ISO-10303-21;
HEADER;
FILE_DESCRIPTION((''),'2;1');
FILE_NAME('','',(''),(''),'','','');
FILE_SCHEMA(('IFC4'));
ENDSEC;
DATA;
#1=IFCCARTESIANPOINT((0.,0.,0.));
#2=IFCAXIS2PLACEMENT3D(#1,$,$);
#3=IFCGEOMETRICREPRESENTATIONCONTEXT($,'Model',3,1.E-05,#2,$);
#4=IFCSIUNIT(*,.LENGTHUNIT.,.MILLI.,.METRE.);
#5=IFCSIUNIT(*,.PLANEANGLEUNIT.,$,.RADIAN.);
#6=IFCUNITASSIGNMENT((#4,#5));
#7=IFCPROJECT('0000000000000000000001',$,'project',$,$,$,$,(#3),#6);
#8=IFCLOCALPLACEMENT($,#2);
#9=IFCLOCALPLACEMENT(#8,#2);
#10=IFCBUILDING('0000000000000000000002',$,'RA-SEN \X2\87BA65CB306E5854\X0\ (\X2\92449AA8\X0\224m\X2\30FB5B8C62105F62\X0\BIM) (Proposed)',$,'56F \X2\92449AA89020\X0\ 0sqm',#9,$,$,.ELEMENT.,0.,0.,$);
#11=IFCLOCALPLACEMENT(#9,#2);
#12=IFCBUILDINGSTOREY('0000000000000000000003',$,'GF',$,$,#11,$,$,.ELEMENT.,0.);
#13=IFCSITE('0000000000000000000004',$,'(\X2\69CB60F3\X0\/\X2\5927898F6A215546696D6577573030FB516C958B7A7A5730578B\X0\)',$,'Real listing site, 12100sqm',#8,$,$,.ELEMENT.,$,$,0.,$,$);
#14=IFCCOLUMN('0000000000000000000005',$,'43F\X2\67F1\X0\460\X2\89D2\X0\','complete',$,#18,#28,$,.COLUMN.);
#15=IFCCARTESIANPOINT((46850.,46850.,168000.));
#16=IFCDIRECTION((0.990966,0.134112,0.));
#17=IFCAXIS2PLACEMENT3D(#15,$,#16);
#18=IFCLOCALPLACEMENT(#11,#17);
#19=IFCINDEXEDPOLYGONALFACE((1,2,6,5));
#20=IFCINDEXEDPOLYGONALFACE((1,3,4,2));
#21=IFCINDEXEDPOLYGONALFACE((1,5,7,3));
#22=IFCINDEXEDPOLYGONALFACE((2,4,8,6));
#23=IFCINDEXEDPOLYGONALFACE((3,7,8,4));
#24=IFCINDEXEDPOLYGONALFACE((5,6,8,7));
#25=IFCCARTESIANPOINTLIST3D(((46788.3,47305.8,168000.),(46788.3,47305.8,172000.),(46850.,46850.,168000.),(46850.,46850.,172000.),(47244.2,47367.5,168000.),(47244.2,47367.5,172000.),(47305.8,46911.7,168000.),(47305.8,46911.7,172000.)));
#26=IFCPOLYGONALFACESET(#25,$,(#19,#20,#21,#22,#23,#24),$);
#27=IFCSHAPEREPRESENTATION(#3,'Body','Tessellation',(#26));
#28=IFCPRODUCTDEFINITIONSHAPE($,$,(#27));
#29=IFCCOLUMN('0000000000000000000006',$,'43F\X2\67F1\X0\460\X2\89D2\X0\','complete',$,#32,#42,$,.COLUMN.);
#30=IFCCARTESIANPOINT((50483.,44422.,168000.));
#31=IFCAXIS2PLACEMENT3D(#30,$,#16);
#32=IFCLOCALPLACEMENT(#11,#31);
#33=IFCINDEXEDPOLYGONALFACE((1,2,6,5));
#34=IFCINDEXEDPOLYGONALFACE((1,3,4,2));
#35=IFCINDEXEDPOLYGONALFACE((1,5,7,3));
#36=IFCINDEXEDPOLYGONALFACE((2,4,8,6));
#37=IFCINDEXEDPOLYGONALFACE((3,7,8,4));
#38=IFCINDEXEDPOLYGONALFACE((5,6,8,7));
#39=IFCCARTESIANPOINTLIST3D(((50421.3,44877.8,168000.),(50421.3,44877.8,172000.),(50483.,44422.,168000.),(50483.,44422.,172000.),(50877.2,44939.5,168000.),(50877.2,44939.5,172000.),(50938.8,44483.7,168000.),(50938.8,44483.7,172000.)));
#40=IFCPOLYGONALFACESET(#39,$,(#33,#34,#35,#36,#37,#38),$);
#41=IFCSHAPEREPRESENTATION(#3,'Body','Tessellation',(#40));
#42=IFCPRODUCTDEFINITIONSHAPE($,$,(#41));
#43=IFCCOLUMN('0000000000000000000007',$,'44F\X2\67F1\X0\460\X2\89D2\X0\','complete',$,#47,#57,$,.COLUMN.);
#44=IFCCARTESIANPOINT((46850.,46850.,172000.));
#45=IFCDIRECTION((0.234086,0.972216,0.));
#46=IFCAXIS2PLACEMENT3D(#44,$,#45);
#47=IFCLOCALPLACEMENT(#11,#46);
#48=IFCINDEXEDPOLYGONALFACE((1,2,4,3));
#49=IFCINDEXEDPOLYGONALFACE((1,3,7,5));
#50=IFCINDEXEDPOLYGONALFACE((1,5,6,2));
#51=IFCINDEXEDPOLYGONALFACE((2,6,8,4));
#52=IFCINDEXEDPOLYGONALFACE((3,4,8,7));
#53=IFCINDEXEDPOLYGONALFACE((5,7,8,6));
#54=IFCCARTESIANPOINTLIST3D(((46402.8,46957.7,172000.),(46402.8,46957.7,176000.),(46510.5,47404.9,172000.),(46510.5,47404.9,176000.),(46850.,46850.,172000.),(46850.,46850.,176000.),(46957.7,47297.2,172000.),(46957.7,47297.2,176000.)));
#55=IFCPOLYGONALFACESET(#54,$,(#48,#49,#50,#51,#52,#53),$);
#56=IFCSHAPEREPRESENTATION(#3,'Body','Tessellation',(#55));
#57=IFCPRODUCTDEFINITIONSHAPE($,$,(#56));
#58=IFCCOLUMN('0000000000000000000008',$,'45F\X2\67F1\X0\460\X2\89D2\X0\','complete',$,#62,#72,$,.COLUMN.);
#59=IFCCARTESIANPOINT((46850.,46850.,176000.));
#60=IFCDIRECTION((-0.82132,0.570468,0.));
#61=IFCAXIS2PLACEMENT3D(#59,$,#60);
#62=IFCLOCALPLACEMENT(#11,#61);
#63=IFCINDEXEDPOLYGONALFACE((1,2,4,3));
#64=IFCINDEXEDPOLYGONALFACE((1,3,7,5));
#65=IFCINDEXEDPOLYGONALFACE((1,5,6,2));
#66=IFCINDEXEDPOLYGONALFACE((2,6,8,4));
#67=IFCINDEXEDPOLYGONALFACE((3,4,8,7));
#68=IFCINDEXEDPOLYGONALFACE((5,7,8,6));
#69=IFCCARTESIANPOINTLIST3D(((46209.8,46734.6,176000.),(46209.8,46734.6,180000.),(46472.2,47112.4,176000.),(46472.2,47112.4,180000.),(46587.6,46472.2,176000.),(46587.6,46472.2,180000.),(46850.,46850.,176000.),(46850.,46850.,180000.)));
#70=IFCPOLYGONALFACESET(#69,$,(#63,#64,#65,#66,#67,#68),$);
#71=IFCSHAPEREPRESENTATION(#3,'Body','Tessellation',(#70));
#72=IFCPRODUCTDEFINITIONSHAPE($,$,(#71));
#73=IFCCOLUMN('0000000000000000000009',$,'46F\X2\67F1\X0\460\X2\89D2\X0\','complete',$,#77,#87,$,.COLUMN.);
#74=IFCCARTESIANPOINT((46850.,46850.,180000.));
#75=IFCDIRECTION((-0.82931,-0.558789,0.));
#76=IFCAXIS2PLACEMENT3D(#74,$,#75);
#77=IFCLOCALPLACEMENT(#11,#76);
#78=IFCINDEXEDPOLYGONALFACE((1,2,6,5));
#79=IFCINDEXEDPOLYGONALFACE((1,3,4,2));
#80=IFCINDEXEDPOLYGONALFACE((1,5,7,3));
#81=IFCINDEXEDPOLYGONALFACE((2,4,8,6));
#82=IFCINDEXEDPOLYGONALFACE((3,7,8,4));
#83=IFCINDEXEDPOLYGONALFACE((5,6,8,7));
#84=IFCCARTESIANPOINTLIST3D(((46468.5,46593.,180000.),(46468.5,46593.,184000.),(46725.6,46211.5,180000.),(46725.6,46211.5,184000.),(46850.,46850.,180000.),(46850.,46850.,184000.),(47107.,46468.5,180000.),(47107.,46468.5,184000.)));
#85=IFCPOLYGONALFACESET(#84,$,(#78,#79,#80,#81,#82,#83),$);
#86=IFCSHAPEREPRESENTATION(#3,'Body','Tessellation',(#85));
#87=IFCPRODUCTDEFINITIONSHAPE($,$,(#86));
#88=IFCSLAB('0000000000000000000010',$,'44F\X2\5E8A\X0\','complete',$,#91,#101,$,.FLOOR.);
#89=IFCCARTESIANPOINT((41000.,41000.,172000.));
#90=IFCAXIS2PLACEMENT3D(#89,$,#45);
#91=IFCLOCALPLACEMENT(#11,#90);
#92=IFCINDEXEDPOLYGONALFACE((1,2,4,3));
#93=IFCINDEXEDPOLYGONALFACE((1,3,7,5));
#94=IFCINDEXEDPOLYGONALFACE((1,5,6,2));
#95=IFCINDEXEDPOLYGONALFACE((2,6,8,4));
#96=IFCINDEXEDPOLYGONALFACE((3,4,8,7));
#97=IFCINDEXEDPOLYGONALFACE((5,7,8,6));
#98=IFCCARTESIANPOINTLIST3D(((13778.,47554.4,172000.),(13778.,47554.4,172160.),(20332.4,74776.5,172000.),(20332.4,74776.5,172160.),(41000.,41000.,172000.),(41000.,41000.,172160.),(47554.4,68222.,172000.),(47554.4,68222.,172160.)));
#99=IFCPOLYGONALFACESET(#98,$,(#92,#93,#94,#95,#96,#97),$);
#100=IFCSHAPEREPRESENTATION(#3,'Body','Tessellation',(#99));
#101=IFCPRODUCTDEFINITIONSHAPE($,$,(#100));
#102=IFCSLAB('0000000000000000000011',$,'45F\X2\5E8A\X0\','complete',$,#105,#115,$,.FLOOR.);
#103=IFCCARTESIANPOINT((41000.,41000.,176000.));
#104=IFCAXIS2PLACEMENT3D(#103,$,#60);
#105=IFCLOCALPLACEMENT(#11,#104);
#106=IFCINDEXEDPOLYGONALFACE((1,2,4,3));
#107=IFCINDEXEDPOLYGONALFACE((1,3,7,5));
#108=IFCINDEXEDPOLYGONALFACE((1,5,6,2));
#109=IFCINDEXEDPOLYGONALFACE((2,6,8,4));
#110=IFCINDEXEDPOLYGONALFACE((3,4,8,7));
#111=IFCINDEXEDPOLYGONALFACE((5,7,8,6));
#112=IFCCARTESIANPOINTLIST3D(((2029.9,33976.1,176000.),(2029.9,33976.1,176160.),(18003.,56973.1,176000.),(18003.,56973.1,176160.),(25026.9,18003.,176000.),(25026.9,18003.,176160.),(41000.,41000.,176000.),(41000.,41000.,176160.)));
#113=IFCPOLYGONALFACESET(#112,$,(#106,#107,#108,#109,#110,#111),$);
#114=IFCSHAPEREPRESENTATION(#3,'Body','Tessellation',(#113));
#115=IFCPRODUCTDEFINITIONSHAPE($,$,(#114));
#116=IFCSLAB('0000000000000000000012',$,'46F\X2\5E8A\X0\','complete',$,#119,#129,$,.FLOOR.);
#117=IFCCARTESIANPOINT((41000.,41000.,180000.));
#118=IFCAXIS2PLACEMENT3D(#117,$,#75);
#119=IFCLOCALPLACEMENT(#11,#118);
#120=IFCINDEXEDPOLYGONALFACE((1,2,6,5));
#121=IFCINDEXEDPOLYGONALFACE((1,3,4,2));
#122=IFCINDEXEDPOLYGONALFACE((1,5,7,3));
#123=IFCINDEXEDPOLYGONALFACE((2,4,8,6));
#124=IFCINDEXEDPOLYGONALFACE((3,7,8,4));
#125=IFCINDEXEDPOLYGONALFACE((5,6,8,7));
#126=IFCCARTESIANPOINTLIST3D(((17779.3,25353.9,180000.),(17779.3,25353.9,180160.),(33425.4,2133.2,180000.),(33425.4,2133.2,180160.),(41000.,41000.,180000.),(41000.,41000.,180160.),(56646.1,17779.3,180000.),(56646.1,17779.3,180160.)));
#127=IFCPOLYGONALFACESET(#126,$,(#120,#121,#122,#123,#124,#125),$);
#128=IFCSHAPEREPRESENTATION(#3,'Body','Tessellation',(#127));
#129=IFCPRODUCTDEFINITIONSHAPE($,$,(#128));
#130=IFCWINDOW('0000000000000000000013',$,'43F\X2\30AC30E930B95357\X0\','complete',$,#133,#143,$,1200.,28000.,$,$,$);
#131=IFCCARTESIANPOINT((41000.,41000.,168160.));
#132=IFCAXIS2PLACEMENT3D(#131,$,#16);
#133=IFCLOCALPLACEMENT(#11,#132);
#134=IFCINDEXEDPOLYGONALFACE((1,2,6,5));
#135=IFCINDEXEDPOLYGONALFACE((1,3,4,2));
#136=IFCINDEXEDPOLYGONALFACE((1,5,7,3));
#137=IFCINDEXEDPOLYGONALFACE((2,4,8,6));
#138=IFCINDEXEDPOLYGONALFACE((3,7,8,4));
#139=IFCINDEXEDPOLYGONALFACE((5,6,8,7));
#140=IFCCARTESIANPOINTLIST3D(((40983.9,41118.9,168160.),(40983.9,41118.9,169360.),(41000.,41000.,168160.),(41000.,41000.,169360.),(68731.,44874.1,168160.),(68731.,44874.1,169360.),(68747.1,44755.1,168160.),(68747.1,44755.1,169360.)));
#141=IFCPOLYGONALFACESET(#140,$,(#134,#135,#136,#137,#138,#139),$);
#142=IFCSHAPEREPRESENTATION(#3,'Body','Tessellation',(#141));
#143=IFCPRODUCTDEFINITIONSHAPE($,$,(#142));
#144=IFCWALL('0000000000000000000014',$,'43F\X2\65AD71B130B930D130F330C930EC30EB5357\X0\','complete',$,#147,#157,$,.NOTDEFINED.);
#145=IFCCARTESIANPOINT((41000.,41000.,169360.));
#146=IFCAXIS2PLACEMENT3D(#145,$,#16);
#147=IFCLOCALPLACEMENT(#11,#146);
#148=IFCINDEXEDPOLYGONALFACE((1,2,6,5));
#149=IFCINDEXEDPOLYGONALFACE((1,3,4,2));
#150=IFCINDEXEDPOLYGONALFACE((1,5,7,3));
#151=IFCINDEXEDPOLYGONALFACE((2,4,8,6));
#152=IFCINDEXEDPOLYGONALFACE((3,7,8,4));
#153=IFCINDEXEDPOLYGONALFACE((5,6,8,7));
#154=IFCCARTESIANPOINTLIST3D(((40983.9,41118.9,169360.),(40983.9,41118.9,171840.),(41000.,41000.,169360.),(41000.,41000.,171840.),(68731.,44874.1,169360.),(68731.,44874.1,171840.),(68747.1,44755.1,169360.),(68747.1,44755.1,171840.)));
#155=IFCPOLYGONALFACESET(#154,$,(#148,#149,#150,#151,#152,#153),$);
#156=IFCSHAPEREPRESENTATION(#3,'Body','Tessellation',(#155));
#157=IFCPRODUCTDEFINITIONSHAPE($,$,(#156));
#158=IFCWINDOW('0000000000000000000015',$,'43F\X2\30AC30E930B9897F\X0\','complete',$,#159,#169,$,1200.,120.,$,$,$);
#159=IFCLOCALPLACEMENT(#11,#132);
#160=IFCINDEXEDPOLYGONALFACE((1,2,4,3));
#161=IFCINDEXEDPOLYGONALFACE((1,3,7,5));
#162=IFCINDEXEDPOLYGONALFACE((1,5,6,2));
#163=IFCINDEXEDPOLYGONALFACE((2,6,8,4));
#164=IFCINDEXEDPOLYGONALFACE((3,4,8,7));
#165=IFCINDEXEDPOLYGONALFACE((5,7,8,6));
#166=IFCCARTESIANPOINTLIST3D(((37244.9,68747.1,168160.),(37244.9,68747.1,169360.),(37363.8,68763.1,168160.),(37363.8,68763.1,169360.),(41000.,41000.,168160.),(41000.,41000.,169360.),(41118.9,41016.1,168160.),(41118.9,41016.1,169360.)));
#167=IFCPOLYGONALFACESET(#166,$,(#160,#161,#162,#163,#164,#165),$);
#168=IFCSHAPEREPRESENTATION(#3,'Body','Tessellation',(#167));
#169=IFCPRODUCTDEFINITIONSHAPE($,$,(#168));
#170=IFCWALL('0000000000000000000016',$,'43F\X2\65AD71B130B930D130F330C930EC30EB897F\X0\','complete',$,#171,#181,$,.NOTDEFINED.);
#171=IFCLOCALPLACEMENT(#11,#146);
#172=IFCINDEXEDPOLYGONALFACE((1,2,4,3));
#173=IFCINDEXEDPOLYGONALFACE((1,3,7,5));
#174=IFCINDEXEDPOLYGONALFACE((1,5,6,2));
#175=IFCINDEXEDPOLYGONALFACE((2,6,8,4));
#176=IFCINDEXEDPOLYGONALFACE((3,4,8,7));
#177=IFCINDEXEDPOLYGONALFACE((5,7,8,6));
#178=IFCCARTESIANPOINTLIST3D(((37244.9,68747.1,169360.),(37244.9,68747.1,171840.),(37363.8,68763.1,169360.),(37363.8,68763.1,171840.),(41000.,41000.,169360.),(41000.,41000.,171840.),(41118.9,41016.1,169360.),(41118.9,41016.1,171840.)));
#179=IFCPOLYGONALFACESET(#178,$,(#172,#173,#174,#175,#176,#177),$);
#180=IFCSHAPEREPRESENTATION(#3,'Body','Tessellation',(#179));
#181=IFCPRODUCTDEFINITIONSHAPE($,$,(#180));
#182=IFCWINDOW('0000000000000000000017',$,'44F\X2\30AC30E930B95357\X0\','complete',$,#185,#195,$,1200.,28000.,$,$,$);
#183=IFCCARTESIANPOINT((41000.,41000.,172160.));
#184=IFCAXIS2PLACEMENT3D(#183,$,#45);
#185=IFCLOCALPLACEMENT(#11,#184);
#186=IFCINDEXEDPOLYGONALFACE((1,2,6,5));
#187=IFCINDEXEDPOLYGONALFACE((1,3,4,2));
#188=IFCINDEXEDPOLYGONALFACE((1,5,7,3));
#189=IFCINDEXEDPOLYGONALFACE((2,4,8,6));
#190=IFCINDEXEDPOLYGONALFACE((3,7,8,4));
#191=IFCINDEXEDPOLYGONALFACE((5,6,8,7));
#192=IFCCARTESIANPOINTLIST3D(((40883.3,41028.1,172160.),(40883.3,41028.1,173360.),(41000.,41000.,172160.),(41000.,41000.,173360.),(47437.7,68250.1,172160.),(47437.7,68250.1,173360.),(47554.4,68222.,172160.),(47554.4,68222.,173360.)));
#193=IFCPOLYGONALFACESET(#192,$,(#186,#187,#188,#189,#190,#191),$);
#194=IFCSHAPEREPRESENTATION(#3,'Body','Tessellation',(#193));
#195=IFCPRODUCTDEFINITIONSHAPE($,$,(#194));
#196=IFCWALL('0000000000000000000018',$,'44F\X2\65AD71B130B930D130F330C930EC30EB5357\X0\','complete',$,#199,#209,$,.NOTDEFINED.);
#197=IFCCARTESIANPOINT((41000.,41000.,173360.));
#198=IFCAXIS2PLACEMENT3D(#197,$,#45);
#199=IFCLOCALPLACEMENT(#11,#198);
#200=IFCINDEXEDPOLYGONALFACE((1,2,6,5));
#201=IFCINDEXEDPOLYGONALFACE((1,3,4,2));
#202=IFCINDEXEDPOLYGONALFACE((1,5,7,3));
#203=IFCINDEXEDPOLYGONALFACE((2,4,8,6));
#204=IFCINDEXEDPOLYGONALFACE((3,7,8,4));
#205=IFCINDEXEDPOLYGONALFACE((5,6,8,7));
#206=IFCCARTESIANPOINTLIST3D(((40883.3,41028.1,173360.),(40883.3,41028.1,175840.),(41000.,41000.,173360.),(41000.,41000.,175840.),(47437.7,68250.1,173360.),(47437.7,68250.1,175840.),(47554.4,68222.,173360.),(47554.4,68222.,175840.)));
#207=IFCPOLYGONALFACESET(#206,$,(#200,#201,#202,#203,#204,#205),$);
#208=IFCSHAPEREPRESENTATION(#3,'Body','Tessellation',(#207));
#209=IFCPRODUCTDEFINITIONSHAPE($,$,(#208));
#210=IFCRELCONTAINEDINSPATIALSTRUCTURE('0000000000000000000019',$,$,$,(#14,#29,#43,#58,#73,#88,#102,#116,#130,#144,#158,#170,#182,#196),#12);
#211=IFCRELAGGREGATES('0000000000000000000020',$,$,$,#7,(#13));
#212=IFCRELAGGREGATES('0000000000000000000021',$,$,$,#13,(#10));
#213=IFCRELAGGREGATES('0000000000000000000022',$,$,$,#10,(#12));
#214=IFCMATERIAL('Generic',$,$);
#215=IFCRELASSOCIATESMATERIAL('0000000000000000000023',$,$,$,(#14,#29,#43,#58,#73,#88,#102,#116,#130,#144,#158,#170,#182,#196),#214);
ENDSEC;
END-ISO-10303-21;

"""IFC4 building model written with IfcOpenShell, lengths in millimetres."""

from ifc_helpers import new_model, si_unit, frame, frame_2d, origin, place, context, project, spatial, rectangle, extrude, material, element, save


model = new_model("IFC4")

# Units and contexts
model_context = context("Model", 3, precision=1e-05, world=origin())
ifc_project = project(units=[si_unit("LENGTHUNIT", "METRE", prefix="MILLI"), si_unit("PLANEANGLEUNIT", "RADIAN")], contexts=[model_context])

# Site, building, storey
site_placement = place(None, origin())
site = spatial("IfcSite", under=ifc_project, at=site_placement, Name="(構想/大規模商業敷地・公開空地型)", ObjectType="Real listing site, 12100sqm", CompositionType="ELEMENT", RefElevation=0.0)
building_placement = place(site_placement, origin())
building = spatial("IfcBuilding", under=site, at=building_placement, Name="RA-SEN 螺旋の塔 (鉄骨224m・完成形BIM) (Proposed)", ObjectType="56F 鉄骨造 0sqm", CompositionType="ELEMENT", ElevationOfRefHeight=0.0, ElevationOfTerrain=0.0)
storey_placement = place(building_placement, origin())
storey = spatial("IfcBuildingStorey", under=building, at=storey_placement, Name="GF", CompositionType="ELEMENT", Elevation=0.0)

# Columns
ifc_material = material(Name="Generic")
column_1_placement = place(storey_placement, frame((46850.0, 46850.0, 168000.0), x_axis=(0.990966, 0.134112, 0.0)))
element("IfcColumn", 1, at=column_1_placement, inside=storey, material=ifc_material, Name="43F柱460角", Description="complete", PredefinedType="COLUMN", context=model_context, shape_type="SweptSolid", body=[
    extrude(rectangle(XDim=460.0, YDim=460.0, at=frame_2d((230.0, 230.0))), frame((46850.0, 46850.0, 168000.0), x_axis=(0.990966, 0.134112, 0.0)), (0.0, 0.0, 1.0), 4000.0),
])
column_2_placement = place(storey_placement, frame((50483.0, 44422.0, 168000.0), x_axis=(0.990966, 0.134112, 0.0)))
element("IfcColumn", 2, at=column_2_placement, inside=storey, material=ifc_material, Name="43F柱460角", Description="complete", PredefinedType="COLUMN", context=model_context, shape_type="SweptSolid", body=[
    extrude(rectangle(XDim=460.0, YDim=460.0, at=frame_2d((230.0, 230.0))), frame((50483.0, 44422.0, 168000.0), x_axis=(0.990966, 0.134112, 0.0)), (0.0, 0.0, 1.0), 4000.0),
])
column_3_placement = place(storey_placement, frame((46850.0, 46850.0, 172000.0), x_axis=(0.234086, 0.972216, 0.0)))
element("IfcColumn", 3, at=column_3_placement, inside=storey, material=ifc_material, Name="44F柱460角", Description="complete", PredefinedType="COLUMN", context=model_context, shape_type="SweptSolid", body=[
    extrude(rectangle(XDim=460.0, YDim=460.0, at=frame_2d((230.0, 230.0))), frame((46850.0, 46850.0, 172000.0), x_axis=(0.234086, 0.972216, 0.0)), (0.0, 0.0, 1.0), 4000.0),
])
column_4_placement = place(storey_placement, frame((46850.0, 46850.0, 176000.0), x_axis=(-0.82132, 0.570468, 0.0)))
element("IfcColumn", 4, at=column_4_placement, inside=storey, material=ifc_material, Name="45F柱460角", Description="complete", PredefinedType="COLUMN", context=model_context, shape_type="SweptSolid", body=[
    extrude(rectangle(XDim=460.0, YDim=460.0, at=frame_2d((230.0, 230.0))), frame((46850.0, 46850.0, 176000.0), x_axis=(-0.82132, 0.570468, 0.0)), (0.0, 0.0, 1.0), 4000.0),
])
column_5_placement = place(storey_placement, frame((46850.0, 46850.0, 180000.0), x_axis=(-0.82931, -0.558789, 0.0)))
element("IfcColumn", 5, at=column_5_placement, inside=storey, material=ifc_material, Name="46F柱460角", Description="complete", PredefinedType="COLUMN", context=model_context, shape_type="SweptSolid", body=[
    extrude(rectangle(XDim=460.0, YDim=460.0, at=frame_2d((230.0, 230.0))), frame((46850.0, 46850.0, 180000.0), x_axis=(-0.82931, -0.558789, 0.0)), (0.0, 0.0, 1.0), 4000.0),
])

# Slabs
slab_1_placement = place(storey_placement, frame((41000.0, 41000.0, 172000.0), x_axis=(0.234086, 0.972216, 0.0)))
element("IfcSlab", 6, at=slab_1_placement, inside=storey, material=ifc_material, Name="44F床", Description="complete", PredefinedType="FLOOR", context=model_context, shape_type="SweptSolid", body=[
    extrude(rectangle(XDim=28000.0, YDim=28000.0, at=frame_2d((14000.0, 14000.0))), frame((41000.0, 41000.0, 172000.0), x_axis=(0.234086, 0.972216, 0.0)), (0.0, 0.0, 1.0), 160.0),
])
slab_2_placement = place(storey_placement, frame((41000.0, 41000.0, 176000.0), x_axis=(-0.82132, 0.570468, 0.0)))
element("IfcSlab", 7, at=slab_2_placement, inside=storey, material=ifc_material, Name="45F床", Description="complete", PredefinedType="FLOOR", context=model_context, shape_type="SweptSolid", body=[
    extrude(rectangle(XDim=28000.0, YDim=28000.0, at=frame_2d((14000.0, 14000.0))), frame((41000.0, 41000.0, 176000.0), x_axis=(-0.82132, 0.570468, 0.0)), (0.0, 0.0, 1.0), 160.0),
])
slab_3_placement = place(storey_placement, frame((41000.0, 41000.0, 180000.0), x_axis=(-0.82931, -0.558789, 0.0)))
element("IfcSlab", 8, at=slab_3_placement, inside=storey, material=ifc_material, Name="46F床", Description="complete", PredefinedType="FLOOR", context=model_context, shape_type="SweptSolid", body=[
    extrude(rectangle(XDim=28000.0, YDim=28000.0, at=frame_2d((14000.0, 14000.0))), frame((41000.0, 41000.0, 180000.0), x_axis=(-0.82931, -0.558789, 0.0)), (0.0, 0.0, 1.0), 160.0),
])

# Window
window_1_placement = place(storey_placement, frame((41000.0, 41000.0, 168160.0), x_axis=(0.990966, 0.134112, 0.0)))
element("IfcWindow", 9, at=window_1_placement, inside=storey, material=ifc_material, Name="43Fガラス南", Description="complete", OverallHeight=1200.0, OverallWidth=28000.0, context=model_context, shape_type="SweptSolid", body=[
    extrude(rectangle(XDim=28000.0, YDim=120.0, at=frame_2d((14000.0, 60.0))), frame((41000.0, 41000.0, 168160.0), x_axis=(0.990966, 0.134112, 0.0)), (0.0, 0.0, 1.0), 1200.0),
])

# Wall
wall_1_placement = place(storey_placement, frame((41000.0, 41000.0, 169360.0), x_axis=(0.990966, 0.134112, 0.0)))
element("IfcWall", 10, at=wall_1_placement, inside=storey, material=ifc_material, Name="43F断熱スパンドレル南", Description="complete", PredefinedType="NOTDEFINED", context=model_context, shape_type="SweptSolid", body=[
    extrude(rectangle(XDim=28000.0, YDim=120.0, at=frame_2d((14000.0, 60.0))), frame((41000.0, 41000.0, 169360.0), x_axis=(0.990966, 0.134112, 0.0)), (0.0, 0.0, 1.0), 2480.0),
])

# Window
window_2_placement = place(storey_placement, frame((41000.0, 41000.0, 168160.0), x_axis=(0.990966, 0.134112, 0.0)))
element("IfcWindow", 11, at=window_2_placement, inside=storey, material=ifc_material, Name="43Fガラス西", Description="complete", OverallHeight=1200.0, OverallWidth=120.0, context=model_context, shape_type="SweptSolid", body=[
    extrude(rectangle(XDim=120.0, YDim=28000.0, at=frame_2d((60.0, 14000.0))), frame((41000.0, 41000.0, 168160.0), x_axis=(0.990966, 0.134112, 0.0)), (0.0, 0.0, 1.0), 1200.0),
])

# Wall
wall_2_placement = place(storey_placement, frame((41000.0, 41000.0, 169360.0), x_axis=(0.990966, 0.134112, 0.0)))
element("IfcWall", 12, at=wall_2_placement, inside=storey, material=ifc_material, Name="43F断熱スパンドレル西", Description="complete", PredefinedType="NOTDEFINED", context=model_context, shape_type="SweptSolid", body=[
    extrude(rectangle(XDim=120.0, YDim=28000.0, at=frame_2d((60.0, 14000.0))), frame((41000.0, 41000.0, 169360.0), x_axis=(0.990966, 0.134112, 0.0)), (0.0, 0.0, 1.0), 2480.0),
])

# Window
window_3_placement = place(storey_placement, frame((41000.0, 41000.0, 172160.0), x_axis=(0.234086, 0.972216, 0.0)))
element("IfcWindow", 13, at=window_3_placement, inside=storey, material=ifc_material, Name="44Fガラス南", Description="complete", OverallHeight=1200.0, OverallWidth=28000.0, context=model_context, shape_type="SweptSolid", body=[
    extrude(rectangle(XDim=28000.0, YDim=120.0, at=frame_2d((14000.0, 60.0))), frame((41000.0, 41000.0, 172160.0), x_axis=(0.234086, 0.972216, 0.0)), (0.0, 0.0, 1.0), 1200.0),
])

# Wall
wall_3_placement = place(storey_placement, frame((41000.0, 41000.0, 173360.0), x_axis=(0.234086, 0.972216, 0.0)))
element("IfcWall", 14, at=wall_3_placement, inside=storey, material=ifc_material, Name="44F断熱スパンドレル南", Description="complete", PredefinedType="NOTDEFINED", context=model_context, shape_type="SweptSolid", body=[
    extrude(rectangle(XDim=28000.0, YDim=120.0, at=frame_2d((14000.0, 60.0))), frame((41000.0, 41000.0, 173360.0), x_axis=(0.234086, 0.972216, 0.0)), (0.0, 0.0, 1.0), 2480.0),
])

save(model, "model.ifc")
